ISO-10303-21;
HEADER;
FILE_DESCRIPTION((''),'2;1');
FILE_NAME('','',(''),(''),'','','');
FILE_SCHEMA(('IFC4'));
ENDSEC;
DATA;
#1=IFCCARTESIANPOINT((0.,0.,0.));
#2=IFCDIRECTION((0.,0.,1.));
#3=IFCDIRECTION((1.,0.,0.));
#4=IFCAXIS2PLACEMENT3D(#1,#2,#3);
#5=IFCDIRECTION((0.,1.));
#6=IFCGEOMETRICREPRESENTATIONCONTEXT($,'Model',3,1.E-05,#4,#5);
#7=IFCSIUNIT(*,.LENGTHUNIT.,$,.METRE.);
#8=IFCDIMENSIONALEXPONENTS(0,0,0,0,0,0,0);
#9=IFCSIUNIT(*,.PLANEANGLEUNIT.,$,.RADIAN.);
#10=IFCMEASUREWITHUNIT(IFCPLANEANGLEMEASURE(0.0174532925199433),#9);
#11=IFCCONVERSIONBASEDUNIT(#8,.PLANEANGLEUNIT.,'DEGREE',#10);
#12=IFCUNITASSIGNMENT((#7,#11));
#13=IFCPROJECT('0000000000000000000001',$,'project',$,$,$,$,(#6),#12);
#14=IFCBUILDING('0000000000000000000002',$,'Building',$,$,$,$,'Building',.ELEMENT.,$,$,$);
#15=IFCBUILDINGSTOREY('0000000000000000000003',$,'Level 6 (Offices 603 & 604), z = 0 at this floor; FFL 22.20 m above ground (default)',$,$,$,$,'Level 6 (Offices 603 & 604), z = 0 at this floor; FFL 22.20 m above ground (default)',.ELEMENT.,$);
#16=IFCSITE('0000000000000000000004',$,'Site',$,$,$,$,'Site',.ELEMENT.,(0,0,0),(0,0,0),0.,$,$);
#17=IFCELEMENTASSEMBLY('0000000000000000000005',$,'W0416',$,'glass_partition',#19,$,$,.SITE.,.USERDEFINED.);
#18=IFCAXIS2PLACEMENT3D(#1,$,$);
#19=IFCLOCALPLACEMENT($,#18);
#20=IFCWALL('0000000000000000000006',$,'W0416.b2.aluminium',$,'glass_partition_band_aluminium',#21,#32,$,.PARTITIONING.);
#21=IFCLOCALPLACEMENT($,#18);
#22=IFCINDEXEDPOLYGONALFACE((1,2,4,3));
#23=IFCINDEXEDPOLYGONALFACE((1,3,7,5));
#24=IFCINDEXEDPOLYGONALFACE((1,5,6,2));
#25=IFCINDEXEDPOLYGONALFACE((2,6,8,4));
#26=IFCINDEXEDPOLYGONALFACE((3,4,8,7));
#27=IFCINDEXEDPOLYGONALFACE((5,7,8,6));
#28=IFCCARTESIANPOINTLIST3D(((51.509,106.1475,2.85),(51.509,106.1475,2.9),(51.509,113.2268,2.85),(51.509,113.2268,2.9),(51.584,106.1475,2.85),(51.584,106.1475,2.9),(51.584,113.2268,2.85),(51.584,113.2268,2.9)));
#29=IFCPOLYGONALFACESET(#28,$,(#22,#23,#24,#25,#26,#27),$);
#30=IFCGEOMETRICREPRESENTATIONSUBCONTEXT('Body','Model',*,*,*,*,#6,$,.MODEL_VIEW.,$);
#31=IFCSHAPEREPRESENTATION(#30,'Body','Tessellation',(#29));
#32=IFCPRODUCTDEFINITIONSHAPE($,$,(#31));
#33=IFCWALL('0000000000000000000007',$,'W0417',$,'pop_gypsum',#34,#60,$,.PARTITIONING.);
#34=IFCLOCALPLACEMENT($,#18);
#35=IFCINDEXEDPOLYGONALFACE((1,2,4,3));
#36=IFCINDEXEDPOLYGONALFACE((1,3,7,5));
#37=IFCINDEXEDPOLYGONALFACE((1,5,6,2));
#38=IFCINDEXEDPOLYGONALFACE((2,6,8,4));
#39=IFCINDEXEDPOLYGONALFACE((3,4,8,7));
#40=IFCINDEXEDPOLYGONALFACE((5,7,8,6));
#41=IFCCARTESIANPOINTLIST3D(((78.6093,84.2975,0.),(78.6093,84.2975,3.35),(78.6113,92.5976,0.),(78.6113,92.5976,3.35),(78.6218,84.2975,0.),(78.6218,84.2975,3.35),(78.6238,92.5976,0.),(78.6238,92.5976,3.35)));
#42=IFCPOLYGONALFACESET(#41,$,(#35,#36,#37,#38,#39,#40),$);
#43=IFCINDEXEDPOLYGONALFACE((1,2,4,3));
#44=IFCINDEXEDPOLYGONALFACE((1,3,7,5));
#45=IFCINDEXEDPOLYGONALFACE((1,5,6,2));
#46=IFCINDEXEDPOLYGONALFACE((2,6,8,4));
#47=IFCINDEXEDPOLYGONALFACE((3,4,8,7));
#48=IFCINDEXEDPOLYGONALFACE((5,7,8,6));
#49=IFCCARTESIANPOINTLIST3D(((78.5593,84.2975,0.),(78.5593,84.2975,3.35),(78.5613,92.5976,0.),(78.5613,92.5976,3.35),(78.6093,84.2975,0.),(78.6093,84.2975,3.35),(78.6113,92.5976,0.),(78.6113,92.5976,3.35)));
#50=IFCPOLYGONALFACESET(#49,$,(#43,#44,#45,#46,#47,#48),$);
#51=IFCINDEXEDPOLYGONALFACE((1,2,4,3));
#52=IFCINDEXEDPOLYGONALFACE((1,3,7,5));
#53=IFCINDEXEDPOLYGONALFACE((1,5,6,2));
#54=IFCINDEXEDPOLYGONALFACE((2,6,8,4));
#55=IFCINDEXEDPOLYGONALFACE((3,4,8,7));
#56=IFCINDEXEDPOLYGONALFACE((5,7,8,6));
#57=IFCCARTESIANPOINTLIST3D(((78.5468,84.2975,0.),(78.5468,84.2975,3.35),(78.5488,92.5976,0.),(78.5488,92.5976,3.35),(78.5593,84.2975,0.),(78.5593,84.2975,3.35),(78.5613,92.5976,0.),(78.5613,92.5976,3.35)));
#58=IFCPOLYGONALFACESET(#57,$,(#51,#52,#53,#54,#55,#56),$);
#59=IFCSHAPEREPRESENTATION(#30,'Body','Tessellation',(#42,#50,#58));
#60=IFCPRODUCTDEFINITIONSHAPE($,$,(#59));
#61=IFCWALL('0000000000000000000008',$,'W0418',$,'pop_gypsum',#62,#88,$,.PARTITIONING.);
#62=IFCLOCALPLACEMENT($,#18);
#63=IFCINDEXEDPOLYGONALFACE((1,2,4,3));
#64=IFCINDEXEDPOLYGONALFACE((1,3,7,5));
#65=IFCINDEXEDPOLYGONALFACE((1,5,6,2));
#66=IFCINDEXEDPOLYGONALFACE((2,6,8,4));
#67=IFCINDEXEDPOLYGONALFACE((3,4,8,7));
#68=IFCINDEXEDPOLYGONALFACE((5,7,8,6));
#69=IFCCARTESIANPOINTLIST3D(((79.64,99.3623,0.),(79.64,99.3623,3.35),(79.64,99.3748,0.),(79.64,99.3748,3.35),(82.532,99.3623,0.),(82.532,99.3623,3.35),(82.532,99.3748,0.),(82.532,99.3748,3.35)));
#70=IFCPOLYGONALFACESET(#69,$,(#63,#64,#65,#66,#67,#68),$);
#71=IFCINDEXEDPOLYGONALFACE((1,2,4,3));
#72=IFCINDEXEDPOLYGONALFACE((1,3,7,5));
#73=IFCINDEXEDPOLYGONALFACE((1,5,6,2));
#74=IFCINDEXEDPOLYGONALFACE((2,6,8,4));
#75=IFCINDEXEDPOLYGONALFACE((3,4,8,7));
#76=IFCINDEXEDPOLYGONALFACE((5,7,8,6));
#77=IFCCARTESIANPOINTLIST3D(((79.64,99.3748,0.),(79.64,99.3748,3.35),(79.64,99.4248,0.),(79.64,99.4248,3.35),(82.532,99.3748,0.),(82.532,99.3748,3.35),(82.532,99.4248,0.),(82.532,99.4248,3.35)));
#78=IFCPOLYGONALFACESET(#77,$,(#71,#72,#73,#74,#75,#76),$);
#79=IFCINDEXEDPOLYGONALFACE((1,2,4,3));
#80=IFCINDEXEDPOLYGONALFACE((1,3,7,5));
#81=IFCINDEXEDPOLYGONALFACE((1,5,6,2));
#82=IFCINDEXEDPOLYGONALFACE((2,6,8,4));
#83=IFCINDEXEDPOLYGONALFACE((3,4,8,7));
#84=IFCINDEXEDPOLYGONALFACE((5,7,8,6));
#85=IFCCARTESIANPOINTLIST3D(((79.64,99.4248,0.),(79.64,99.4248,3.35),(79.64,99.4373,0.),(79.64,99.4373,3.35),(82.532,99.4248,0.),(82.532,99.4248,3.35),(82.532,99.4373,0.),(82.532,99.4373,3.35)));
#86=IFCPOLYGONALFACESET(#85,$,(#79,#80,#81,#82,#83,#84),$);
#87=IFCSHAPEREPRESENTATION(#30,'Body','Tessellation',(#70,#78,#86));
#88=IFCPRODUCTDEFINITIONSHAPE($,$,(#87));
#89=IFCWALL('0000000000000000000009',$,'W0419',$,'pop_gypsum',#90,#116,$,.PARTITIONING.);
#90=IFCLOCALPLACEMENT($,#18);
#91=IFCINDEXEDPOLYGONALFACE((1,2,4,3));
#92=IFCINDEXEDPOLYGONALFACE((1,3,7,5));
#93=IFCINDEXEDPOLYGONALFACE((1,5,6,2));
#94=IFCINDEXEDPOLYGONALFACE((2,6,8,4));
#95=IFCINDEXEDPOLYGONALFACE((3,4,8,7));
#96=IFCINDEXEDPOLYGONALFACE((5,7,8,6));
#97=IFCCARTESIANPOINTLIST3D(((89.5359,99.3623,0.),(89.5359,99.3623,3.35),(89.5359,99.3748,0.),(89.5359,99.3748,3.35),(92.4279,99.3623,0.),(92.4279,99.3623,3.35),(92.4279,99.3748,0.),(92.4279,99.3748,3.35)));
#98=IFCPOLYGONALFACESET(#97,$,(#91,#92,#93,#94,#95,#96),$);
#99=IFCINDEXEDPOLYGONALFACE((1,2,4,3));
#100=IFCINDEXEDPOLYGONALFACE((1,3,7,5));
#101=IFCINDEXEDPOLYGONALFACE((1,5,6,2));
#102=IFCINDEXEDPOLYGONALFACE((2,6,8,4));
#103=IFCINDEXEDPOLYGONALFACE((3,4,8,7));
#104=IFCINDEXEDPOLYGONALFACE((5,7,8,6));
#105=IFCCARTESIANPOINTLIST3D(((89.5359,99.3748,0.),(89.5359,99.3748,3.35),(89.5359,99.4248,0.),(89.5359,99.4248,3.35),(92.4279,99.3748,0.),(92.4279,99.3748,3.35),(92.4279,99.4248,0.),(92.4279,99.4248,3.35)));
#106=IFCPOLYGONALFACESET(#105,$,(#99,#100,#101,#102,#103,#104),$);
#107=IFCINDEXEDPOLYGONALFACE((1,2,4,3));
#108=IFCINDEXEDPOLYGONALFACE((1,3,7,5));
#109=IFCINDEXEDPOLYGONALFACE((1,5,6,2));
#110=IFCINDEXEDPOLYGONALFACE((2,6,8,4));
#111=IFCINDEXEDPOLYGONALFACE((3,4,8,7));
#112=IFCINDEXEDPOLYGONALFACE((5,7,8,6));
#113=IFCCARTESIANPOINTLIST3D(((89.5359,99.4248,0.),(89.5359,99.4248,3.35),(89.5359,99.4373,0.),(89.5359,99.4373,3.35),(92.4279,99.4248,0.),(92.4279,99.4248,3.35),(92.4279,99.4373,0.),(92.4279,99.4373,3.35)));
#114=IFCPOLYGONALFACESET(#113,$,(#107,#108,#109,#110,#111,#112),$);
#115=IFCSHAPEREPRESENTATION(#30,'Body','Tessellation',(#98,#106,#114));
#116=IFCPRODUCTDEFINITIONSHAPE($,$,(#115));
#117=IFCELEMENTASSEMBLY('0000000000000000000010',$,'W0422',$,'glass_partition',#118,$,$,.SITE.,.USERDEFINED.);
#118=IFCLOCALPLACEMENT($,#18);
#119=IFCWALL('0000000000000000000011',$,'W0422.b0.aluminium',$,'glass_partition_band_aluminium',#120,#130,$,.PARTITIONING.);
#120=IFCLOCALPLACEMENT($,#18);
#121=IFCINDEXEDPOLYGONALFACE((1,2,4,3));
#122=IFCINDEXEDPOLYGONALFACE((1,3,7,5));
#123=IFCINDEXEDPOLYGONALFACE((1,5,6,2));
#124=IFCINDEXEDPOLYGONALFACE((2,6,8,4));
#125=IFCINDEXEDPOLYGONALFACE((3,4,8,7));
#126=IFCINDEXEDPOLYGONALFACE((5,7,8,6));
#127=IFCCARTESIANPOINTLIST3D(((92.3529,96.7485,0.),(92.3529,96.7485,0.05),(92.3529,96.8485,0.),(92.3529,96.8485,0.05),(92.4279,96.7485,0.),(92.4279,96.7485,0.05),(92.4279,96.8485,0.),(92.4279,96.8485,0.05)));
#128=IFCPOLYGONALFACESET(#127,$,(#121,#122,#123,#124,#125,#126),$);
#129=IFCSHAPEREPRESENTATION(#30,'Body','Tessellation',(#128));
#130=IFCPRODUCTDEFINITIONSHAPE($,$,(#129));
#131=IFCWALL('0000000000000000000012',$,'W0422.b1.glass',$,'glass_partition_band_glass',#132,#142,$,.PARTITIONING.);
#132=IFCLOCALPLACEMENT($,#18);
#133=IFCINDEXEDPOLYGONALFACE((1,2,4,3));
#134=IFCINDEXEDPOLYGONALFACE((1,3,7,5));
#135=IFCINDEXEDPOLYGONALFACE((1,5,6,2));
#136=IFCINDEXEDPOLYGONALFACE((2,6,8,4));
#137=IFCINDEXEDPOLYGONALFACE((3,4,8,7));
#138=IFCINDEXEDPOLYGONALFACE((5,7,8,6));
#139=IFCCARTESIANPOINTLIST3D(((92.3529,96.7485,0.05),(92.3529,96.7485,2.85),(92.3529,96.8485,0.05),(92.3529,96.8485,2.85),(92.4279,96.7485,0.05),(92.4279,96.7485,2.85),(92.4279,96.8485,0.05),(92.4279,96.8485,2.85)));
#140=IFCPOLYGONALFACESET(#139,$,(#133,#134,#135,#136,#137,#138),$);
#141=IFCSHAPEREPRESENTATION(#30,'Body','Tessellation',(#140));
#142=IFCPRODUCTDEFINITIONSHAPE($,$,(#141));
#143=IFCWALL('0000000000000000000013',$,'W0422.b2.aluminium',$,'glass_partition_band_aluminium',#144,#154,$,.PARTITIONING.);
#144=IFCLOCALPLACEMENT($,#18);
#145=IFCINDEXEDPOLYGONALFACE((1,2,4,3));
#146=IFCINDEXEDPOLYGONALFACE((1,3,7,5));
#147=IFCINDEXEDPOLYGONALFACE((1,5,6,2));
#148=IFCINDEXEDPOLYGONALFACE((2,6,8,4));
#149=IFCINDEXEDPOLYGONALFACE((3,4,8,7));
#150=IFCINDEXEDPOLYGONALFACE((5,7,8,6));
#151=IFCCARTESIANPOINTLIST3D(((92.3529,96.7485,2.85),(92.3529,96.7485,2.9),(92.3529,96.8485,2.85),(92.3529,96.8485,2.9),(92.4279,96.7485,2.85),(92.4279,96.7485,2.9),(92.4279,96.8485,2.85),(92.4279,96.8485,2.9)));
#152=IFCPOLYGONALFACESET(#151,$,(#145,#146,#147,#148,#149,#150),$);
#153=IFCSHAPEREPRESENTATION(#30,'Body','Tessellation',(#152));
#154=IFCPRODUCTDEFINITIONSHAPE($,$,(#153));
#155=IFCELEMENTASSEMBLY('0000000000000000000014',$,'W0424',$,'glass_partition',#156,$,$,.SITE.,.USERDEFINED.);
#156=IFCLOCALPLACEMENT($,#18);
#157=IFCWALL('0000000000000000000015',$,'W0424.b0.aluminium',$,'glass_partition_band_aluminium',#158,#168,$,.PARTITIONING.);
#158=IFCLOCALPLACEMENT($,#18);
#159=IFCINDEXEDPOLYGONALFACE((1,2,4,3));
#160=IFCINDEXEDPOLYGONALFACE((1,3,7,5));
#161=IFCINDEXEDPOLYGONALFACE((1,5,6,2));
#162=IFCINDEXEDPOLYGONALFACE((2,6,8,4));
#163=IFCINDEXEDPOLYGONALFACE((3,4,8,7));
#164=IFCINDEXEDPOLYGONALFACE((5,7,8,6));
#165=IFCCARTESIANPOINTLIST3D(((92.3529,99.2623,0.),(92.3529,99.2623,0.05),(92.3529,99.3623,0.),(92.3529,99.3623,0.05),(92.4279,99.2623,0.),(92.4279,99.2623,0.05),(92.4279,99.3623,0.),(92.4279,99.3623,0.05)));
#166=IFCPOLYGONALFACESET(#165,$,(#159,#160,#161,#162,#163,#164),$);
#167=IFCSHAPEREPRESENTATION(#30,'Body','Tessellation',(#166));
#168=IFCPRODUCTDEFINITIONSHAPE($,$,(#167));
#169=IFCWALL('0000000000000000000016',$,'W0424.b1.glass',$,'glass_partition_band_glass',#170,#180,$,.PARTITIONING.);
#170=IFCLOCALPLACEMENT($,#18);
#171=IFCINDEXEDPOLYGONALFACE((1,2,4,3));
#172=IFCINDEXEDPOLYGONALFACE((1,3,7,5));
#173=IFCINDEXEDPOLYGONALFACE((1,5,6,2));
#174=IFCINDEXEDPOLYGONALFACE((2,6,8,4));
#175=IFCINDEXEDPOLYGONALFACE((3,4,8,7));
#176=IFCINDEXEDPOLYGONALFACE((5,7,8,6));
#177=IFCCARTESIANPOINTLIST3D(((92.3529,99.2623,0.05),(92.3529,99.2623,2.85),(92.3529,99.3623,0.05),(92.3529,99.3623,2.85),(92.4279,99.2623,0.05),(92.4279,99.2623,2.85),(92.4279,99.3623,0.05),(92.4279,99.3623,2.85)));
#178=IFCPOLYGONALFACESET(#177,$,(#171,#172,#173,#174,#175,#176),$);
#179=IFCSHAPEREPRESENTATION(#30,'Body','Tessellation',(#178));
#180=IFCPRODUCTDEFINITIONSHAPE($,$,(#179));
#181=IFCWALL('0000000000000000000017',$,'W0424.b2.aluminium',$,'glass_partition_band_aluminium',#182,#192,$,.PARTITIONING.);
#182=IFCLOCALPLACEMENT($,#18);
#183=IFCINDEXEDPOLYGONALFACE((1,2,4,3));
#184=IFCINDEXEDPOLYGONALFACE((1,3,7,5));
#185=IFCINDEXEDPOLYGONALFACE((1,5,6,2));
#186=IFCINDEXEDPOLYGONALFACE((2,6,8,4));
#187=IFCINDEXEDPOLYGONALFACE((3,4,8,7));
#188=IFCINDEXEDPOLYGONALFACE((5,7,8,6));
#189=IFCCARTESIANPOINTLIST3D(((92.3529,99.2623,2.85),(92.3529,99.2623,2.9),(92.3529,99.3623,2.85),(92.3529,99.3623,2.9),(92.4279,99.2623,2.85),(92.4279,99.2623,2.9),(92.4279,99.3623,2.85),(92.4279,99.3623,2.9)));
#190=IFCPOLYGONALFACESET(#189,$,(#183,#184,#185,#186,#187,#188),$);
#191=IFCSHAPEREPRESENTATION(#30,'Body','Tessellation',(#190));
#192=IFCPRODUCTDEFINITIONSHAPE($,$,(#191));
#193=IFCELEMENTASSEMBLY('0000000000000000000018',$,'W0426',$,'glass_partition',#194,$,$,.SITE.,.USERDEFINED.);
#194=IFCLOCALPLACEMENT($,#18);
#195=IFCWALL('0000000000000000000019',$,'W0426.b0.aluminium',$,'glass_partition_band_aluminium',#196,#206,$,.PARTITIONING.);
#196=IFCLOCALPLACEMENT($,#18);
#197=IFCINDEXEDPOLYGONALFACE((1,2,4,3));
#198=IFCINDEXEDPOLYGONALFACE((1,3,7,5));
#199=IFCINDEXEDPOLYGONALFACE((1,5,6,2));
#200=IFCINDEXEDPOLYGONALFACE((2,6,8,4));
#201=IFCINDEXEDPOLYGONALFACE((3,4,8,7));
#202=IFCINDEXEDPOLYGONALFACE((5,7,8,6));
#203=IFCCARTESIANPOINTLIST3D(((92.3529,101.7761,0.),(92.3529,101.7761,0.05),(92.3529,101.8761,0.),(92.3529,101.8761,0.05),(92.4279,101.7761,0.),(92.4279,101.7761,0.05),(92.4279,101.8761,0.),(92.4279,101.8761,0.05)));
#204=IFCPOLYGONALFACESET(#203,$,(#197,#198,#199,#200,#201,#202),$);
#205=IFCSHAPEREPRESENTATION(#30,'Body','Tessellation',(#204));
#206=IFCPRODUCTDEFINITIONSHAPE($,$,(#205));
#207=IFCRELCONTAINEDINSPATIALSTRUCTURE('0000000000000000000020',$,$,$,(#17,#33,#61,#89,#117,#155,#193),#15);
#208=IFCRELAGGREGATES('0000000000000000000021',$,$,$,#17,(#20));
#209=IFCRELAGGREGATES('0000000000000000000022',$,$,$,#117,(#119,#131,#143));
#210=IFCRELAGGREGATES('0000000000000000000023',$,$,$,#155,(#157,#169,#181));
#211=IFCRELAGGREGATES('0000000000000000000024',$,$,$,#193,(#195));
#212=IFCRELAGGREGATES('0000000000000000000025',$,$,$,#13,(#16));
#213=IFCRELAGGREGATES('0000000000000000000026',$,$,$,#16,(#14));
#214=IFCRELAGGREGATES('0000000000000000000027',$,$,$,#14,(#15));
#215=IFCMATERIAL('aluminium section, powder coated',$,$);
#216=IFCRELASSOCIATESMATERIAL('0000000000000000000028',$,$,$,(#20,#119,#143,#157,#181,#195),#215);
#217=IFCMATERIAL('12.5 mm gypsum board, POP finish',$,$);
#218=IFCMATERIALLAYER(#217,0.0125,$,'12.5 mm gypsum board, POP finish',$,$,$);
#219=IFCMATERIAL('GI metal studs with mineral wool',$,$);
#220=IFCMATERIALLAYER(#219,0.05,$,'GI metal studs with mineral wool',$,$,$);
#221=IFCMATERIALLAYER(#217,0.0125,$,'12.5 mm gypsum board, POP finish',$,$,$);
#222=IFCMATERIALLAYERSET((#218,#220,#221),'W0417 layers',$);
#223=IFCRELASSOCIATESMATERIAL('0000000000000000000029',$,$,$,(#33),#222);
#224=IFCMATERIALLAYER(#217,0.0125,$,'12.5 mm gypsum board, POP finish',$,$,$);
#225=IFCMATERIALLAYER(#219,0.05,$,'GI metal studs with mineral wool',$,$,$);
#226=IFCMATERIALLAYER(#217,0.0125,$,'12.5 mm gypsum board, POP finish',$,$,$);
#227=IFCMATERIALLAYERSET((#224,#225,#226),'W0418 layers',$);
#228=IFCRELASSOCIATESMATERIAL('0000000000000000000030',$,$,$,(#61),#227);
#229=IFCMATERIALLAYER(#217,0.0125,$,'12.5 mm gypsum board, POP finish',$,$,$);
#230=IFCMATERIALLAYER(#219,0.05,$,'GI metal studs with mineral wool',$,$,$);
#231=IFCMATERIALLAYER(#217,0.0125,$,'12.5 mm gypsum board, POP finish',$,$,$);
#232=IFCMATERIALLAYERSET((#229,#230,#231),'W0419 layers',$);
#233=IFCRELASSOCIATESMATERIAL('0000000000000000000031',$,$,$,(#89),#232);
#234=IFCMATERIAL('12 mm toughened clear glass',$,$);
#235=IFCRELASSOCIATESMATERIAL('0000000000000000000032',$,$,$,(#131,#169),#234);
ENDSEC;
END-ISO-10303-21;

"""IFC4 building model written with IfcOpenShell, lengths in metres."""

from ifc_helpers import new_model, entity, si_unit, converted_unit, direction, frame, frame_2d, origin_with_axes, place, context, subcontext, project, spatial, rectangle, extrude, material, layer, layer_set, layer_usage, element, aggregate, save


model = new_model("IFC4")

# Units and contexts
model_context = context("Model", 3, precision=1e-05, world=origin_with_axes(), true_north=direction((0.0, 1.0)))
body_context = subcontext(model_context, "Body", "Model", "MODEL_VIEW")
ifc_project = project(units=[si_unit("LENGTHUNIT", "METRE"), converted_unit("PLANEANGLEUNIT", "DEGREE", entity("IfcPlaneAngleMeasure", 0.0174532925199433), si_unit("PLANEANGLEUNIT", "RADIAN"), dimensions=[0, 0, 0, 0, 0, 0, 0])], contexts=[model_context])

# Site, building, storey
site = spatial("IfcSite", under=ifc_project, Name="Site", LongName="Site", CompositionType="ELEMENT", RefLatitude=(0, 0, 0), RefLongitude=(0, 0, 0), RefElevation=0.0)
building = spatial("IfcBuilding", under=site, Name="Building", LongName="Building", CompositionType="ELEMENT")
storey = spatial("IfcBuildingStorey", under=building, Name="Level 6 (Offices 603 & 604), z = 0 at this floor; FFL 22.20 m above ground (default)", LongName="Level 6 (Offices 603 & 604), z = 0 at this floor; FFL 22.20 m above ground (default)", CompositionType="ELEMENT")

# Element assembly, wall
assembly_1 = element("IfcElementAssembly", 1, inside=storey, Name="W0416", ObjectType="glass_partition", AssemblyPlace="SITE", PredefinedType="USERDEFINED")
ifc_material_1 = material(Name="aluminium section, powder coated")
placement = place(None, origin_with_axes())
wall_1 = element("IfcWall", 2, at=placement, material=ifc_material_1, Name="W0416.b2.aluminium", ObjectType="glass_partition_band_aluminium", PredefinedType="PARTITIONING", context=body_context, shape_type="SweptSolid", body=[
    extrude(rectangle(XDim=7.0793, YDim=0.075, at=frame_2d((0.0, 0.0), x_axis=(0.0, 1.0))), frame((51.5465, 109.6872, 2.85), z_axis=(0.0, 0.0, 1.0), x_axis=(1.0, 0.0, 0.0)), (0.0, 0.0, 1.0), 0.05),
])
aggregate(assembly_1, [wall_1])

# Walls
ifc_material_2 = material(Name="12.5 mm gypsum board, POP finish")
ifc_layer_1 = layer(ifc_material_2, 0.0125, Name="12.5 mm gypsum board, POP finish")
ifc_material_3 = material(Name="GI metal studs with mineral wool")
ifc_layer_2 = layer(ifc_material_3, 0.05, Name="GI metal studs with mineral wool")
ifc_layer_3 = layer(ifc_material_2, 0.0125, Name="12.5 mm gypsum board, POP finish")
ifc_layer_set_1 = layer_set([ifc_layer_1, ifc_layer_2, ifc_layer_3], Name="W0417 layers")
ifc_layer_usage_1 = layer_usage(ifc_layer_set_1, "AXIS2", "POSITIVE", -0.0375)
element("IfcWall", 3, at=placement, inside=storey, material=ifc_layer_usage_1, Name="W0417", ObjectType="pop_gypsum", PredefinedType="PARTITIONING", context=body_context, shape_type="SweptSolid", body=[
    extrude(rectangle(XDim=8.3001, YDim=0.0125, at=frame_2d((0.0, 0.0), x_axis=(0.000241, 1.0))), frame((78.6165, 88.4475, 0.0), z_axis=(0.0, 0.0, 1.0), x_axis=(1.0, 0.0, 0.0)), (0.0, 0.0, 1.0), 3.35),
    extrude(rectangle(XDim=8.3001, YDim=0.05, at=frame_2d((-0.0312, 0.0), x_axis=(0.000241, 1.0))), frame((78.6165, 88.4475, 0.0), z_axis=(0.0, 0.0, 1.0), x_axis=(1.0, 0.0, 0.0)), (0.0, 0.0, 1.0), 3.35),
    extrude(rectangle(XDim=8.3001, YDim=0.0125, at=frame_2d((-0.0625, 0.0), x_axis=(0.000241, 1.0))), frame((78.6165, 88.4475, 0.0), z_axis=(0.0, 0.0, 1.0), x_axis=(1.0, 0.0, 0.0)), (0.0, 0.0, 1.0), 3.35),
])
ifc_layer_4 = layer(ifc_material_2, 0.0125, Name="12.5 mm gypsum board, POP finish")
ifc_layer_5 = layer(ifc_material_3, 0.05, Name="GI metal studs with mineral wool")
ifc_layer_6 = layer(ifc_material_2, 0.0125, Name="12.5 mm gypsum board, POP finish")
ifc_layer_set_2 = layer_set([ifc_layer_4, ifc_layer_5, ifc_layer_6], Name="W0418 layers")
ifc_layer_usage_2 = layer_usage(ifc_layer_set_2, "AXIS2", "POSITIVE", -0.0375)
element("IfcWall", 4, at=placement, inside=storey, material=ifc_layer_usage_2, Name="W0418", ObjectType="pop_gypsum", PredefinedType="PARTITIONING", context=body_context, shape_type="SweptSolid", body=[
    extrude(rectangle(XDim=2.892, YDim=0.0125, at=frame_2d((0.0, 0.0), x_axis=(1.0, 0.0))), frame((81.086, 99.3685, 0.0), z_axis=(0.0, 0.0, 1.0), x_axis=(1.0, 0.0, 0.0)), (0.0, 0.0, 1.0), 3.35),
    extrude(rectangle(XDim=2.892, YDim=0.05, at=frame_2d((0.0, 0.0313), x_axis=(1.0, 0.0))), frame((81.086, 99.3685, 0.0), z_axis=(0.0, 0.0, 1.0), x_axis=(1.0, 0.0, 0.0)), (0.0, 0.0, 1.0), 3.35),
    extrude(rectangle(XDim=2.892, YDim=0.0125, at=frame_2d((0.0, 0.0625), x_axis=(1.0, 0.0))), frame((81.086, 99.3685, 0.0), z_axis=(0.0, 0.0, 1.0), x_axis=(1.0, 0.0, 0.0)), (0.0, 0.0, 1.0), 3.35),
])
ifc_layer_7 = layer(ifc_material_2, 0.0125, Name="12.5 mm gypsum board, POP finish")
ifc_layer_8 = layer(ifc_material_3, 0.05, Name="GI metal studs with mineral wool")
ifc_layer_9 = layer(ifc_material_2, 0.0125, Name="12.5 mm gypsum board, POP finish")
ifc_layer_set_3 = layer_set([ifc_layer_7, ifc_layer_8, ifc_layer_9], Name="W0419 layers")
ifc_layer_usage_3 = layer_usage(ifc_layer_set_3, "AXIS2", "POSITIVE", -0.0375)
element("IfcWall", 5, at=placement, inside=storey, material=ifc_layer_usage_3, Name="W0419", ObjectType="pop_gypsum", PredefinedType="PARTITIONING", context=body_context, shape_type="SweptSolid", body=[
    extrude(rectangle(XDim=2.892, YDim=0.0125, at=frame_2d((0.0, 0.0), x_axis=(1.0, 0.0))), frame((90.9819, 99.3685, 0.0), z_axis=(0.0, 0.0, 1.0), x_axis=(1.0, 0.0, 0.0)), (0.0, 0.0, 1.0), 3.35),
    extrude(rectangle(XDim=2.892, YDim=0.05, at=frame_2d((0.0, 0.0313), x_axis=(1.0, 0.0))), frame((90.9819, 99.3685, 0.0), z_axis=(0.0, 0.0, 1.0), x_axis=(1.0, 0.0, 0.0)), (0.0, 0.0, 1.0), 3.35),
    extrude(rectangle(XDim=2.892, YDim=0.0125, at=frame_2d((0.0, 0.0625), x_axis=(1.0, 0.0))), frame((90.9819, 99.3685, 0.0), z_axis=(0.0, 0.0, 1.0), x_axis=(1.0, 0.0, 0.0)), (0.0, 0.0, 1.0), 3.35),
])

# Element assemblies, walls
assembly_2 = element("IfcElementAssembly", 6, inside=storey, Name="W0422", ObjectType="glass_partition", AssemblyPlace="SITE", PredefinedType="USERDEFINED")
wall_2 = element("IfcWall", 7, at=placement, material=ifc_material_1, Name="W0422.b0.aluminium", ObjectType="glass_partition_band_aluminium", PredefinedType="PARTITIONING", context=body_context, shape_type="SweptSolid", body=[
    extrude(rectangle(XDim=0.1, YDim=0.075, at=frame_2d((0.0, 0.0), x_axis=(0.0, 1.0))), frame((92.3904, 96.7985, 0.0), z_axis=(0.0, 0.0, 1.0), x_axis=(1.0, 0.0, 0.0)), (0.0, 0.0, 1.0), 0.05),
])
ifc_material_4 = material(Name="12 mm toughened clear glass")
wall_3 = element("IfcWall", 8, at=placement, material=ifc_material_4, Name="W0422.b1.glass", ObjectType="glass_partition_band_glass", PredefinedType="PARTITIONING", context=body_context, shape_type="SweptSolid", body=[
    extrude(rectangle(XDim=0.1, YDim=0.075, at=frame_2d((0.0, 0.0), x_axis=(0.0, 1.0))), frame((92.3904, 96.7985, 0.05), z_axis=(0.0, 0.0, 1.0), x_axis=(1.0, 0.0, 0.0)), (0.0, 0.0, 1.0), 2.8),
])
wall_4 = element("IfcWall", 9, at=placement, material=ifc_material_1, Name="W0422.b2.aluminium", ObjectType="glass_partition_band_aluminium", PredefinedType="PARTITIONING", context=body_context, shape_type="SweptSolid", body=[
    extrude(rectangle(XDim=0.1, YDim=0.075, at=frame_2d((0.0, 0.0), x_axis=(0.0, 1.0))), frame((92.3904, 96.7985, 2.85), z_axis=(0.0, 0.0, 1.0), x_axis=(1.0, 0.0, 0.0)), (0.0, 0.0, 1.0), 0.05),
])
aggregate(assembly_2, [wall_2, wall_3, wall_4])
assembly_3 = element("IfcElementAssembly", 10, inside=storey, Name="W0424", ObjectType="glass_partition", AssemblyPlace="SITE", PredefinedType="USERDEFINED")
wall_5 = element("IfcWall", 11, at=placement, material=ifc_material_1, Name="W0424.b0.aluminium", ObjectType="glass_partition_band_aluminium", PredefinedType="PARTITIONING", context=body_context, shape_type="SweptSolid", body=[
    extrude(rectangle(XDim=0.1, YDim=0.075, at=frame_2d((0.0, 0.0), x_axis=(0.0, 1.0))), frame((92.3904, 99.3123, 0.0), z_axis=(0.0, 0.0, 1.0), x_axis=(1.0, 0.0, 0.0)), (0.0, 0.0, 1.0), 0.05),
])
wall_6 = element("IfcWall", 12, at=placement, material=ifc_material_4, Name="W0424.b1.glass", ObjectType="glass_partition_band_glass", PredefinedType="PARTITIONING", context=body_context, shape_type="SweptSolid", body=[
    extrude(rectangle(XDim=0.1, YDim=0.075, at=frame_2d((0.0, 0.0), x_axis=(0.0, 1.0))), frame((92.3904, 99.3123, 0.05), z_axis=(0.0, 0.0, 1.0), x_axis=(1.0, 0.0, 0.0)), (0.0, 0.0, 1.0), 2.8),
])
wall_7 = element("IfcWall", 13, at=placement, material=ifc_material_1, Name="W0424.b2.aluminium", ObjectType="glass_partition_band_aluminium", PredefinedType="PARTITIONING", context=body_context, shape_type="SweptSolid", body=[
    extrude(rectangle(XDim=0.1, YDim=0.075, at=frame_2d((0.0, 0.0), x_axis=(0.0, 1.0))), frame((92.3904, 99.3123, 2.85), z_axis=(0.0, 0.0, 1.0), x_axis=(1.0, 0.0, 0.0)), (0.0, 0.0, 1.0), 0.05),
])
aggregate(assembly_3, [wall_5, wall_6, wall_7])
assembly_4 = element("IfcElementAssembly", 14, inside=storey, Name="W0426", ObjectType="glass_partition", AssemblyPlace="SITE", PredefinedType="USERDEFINED")
wall_8 = element("IfcWall", 15, at=placement, material=ifc_material_1, Name="W0426.b0.aluminium", ObjectType="glass_partition_band_aluminium", PredefinedType="PARTITIONING", context=body_context, shape_type="SweptSolid", body=[
    extrude(rectangle(XDim=0.1, YDim=0.075, at=frame_2d((0.0, 0.0), x_axis=(0.0, 1.0))), frame((92.3904, 101.8261, 0.0), z_axis=(0.0, 0.0, 1.0), x_axis=(1.0, 0.0, 0.0)), (0.0, 0.0, 1.0), 0.05),
])
aggregate(assembly_4, [wall_8])

save(model, "model.ifc")
